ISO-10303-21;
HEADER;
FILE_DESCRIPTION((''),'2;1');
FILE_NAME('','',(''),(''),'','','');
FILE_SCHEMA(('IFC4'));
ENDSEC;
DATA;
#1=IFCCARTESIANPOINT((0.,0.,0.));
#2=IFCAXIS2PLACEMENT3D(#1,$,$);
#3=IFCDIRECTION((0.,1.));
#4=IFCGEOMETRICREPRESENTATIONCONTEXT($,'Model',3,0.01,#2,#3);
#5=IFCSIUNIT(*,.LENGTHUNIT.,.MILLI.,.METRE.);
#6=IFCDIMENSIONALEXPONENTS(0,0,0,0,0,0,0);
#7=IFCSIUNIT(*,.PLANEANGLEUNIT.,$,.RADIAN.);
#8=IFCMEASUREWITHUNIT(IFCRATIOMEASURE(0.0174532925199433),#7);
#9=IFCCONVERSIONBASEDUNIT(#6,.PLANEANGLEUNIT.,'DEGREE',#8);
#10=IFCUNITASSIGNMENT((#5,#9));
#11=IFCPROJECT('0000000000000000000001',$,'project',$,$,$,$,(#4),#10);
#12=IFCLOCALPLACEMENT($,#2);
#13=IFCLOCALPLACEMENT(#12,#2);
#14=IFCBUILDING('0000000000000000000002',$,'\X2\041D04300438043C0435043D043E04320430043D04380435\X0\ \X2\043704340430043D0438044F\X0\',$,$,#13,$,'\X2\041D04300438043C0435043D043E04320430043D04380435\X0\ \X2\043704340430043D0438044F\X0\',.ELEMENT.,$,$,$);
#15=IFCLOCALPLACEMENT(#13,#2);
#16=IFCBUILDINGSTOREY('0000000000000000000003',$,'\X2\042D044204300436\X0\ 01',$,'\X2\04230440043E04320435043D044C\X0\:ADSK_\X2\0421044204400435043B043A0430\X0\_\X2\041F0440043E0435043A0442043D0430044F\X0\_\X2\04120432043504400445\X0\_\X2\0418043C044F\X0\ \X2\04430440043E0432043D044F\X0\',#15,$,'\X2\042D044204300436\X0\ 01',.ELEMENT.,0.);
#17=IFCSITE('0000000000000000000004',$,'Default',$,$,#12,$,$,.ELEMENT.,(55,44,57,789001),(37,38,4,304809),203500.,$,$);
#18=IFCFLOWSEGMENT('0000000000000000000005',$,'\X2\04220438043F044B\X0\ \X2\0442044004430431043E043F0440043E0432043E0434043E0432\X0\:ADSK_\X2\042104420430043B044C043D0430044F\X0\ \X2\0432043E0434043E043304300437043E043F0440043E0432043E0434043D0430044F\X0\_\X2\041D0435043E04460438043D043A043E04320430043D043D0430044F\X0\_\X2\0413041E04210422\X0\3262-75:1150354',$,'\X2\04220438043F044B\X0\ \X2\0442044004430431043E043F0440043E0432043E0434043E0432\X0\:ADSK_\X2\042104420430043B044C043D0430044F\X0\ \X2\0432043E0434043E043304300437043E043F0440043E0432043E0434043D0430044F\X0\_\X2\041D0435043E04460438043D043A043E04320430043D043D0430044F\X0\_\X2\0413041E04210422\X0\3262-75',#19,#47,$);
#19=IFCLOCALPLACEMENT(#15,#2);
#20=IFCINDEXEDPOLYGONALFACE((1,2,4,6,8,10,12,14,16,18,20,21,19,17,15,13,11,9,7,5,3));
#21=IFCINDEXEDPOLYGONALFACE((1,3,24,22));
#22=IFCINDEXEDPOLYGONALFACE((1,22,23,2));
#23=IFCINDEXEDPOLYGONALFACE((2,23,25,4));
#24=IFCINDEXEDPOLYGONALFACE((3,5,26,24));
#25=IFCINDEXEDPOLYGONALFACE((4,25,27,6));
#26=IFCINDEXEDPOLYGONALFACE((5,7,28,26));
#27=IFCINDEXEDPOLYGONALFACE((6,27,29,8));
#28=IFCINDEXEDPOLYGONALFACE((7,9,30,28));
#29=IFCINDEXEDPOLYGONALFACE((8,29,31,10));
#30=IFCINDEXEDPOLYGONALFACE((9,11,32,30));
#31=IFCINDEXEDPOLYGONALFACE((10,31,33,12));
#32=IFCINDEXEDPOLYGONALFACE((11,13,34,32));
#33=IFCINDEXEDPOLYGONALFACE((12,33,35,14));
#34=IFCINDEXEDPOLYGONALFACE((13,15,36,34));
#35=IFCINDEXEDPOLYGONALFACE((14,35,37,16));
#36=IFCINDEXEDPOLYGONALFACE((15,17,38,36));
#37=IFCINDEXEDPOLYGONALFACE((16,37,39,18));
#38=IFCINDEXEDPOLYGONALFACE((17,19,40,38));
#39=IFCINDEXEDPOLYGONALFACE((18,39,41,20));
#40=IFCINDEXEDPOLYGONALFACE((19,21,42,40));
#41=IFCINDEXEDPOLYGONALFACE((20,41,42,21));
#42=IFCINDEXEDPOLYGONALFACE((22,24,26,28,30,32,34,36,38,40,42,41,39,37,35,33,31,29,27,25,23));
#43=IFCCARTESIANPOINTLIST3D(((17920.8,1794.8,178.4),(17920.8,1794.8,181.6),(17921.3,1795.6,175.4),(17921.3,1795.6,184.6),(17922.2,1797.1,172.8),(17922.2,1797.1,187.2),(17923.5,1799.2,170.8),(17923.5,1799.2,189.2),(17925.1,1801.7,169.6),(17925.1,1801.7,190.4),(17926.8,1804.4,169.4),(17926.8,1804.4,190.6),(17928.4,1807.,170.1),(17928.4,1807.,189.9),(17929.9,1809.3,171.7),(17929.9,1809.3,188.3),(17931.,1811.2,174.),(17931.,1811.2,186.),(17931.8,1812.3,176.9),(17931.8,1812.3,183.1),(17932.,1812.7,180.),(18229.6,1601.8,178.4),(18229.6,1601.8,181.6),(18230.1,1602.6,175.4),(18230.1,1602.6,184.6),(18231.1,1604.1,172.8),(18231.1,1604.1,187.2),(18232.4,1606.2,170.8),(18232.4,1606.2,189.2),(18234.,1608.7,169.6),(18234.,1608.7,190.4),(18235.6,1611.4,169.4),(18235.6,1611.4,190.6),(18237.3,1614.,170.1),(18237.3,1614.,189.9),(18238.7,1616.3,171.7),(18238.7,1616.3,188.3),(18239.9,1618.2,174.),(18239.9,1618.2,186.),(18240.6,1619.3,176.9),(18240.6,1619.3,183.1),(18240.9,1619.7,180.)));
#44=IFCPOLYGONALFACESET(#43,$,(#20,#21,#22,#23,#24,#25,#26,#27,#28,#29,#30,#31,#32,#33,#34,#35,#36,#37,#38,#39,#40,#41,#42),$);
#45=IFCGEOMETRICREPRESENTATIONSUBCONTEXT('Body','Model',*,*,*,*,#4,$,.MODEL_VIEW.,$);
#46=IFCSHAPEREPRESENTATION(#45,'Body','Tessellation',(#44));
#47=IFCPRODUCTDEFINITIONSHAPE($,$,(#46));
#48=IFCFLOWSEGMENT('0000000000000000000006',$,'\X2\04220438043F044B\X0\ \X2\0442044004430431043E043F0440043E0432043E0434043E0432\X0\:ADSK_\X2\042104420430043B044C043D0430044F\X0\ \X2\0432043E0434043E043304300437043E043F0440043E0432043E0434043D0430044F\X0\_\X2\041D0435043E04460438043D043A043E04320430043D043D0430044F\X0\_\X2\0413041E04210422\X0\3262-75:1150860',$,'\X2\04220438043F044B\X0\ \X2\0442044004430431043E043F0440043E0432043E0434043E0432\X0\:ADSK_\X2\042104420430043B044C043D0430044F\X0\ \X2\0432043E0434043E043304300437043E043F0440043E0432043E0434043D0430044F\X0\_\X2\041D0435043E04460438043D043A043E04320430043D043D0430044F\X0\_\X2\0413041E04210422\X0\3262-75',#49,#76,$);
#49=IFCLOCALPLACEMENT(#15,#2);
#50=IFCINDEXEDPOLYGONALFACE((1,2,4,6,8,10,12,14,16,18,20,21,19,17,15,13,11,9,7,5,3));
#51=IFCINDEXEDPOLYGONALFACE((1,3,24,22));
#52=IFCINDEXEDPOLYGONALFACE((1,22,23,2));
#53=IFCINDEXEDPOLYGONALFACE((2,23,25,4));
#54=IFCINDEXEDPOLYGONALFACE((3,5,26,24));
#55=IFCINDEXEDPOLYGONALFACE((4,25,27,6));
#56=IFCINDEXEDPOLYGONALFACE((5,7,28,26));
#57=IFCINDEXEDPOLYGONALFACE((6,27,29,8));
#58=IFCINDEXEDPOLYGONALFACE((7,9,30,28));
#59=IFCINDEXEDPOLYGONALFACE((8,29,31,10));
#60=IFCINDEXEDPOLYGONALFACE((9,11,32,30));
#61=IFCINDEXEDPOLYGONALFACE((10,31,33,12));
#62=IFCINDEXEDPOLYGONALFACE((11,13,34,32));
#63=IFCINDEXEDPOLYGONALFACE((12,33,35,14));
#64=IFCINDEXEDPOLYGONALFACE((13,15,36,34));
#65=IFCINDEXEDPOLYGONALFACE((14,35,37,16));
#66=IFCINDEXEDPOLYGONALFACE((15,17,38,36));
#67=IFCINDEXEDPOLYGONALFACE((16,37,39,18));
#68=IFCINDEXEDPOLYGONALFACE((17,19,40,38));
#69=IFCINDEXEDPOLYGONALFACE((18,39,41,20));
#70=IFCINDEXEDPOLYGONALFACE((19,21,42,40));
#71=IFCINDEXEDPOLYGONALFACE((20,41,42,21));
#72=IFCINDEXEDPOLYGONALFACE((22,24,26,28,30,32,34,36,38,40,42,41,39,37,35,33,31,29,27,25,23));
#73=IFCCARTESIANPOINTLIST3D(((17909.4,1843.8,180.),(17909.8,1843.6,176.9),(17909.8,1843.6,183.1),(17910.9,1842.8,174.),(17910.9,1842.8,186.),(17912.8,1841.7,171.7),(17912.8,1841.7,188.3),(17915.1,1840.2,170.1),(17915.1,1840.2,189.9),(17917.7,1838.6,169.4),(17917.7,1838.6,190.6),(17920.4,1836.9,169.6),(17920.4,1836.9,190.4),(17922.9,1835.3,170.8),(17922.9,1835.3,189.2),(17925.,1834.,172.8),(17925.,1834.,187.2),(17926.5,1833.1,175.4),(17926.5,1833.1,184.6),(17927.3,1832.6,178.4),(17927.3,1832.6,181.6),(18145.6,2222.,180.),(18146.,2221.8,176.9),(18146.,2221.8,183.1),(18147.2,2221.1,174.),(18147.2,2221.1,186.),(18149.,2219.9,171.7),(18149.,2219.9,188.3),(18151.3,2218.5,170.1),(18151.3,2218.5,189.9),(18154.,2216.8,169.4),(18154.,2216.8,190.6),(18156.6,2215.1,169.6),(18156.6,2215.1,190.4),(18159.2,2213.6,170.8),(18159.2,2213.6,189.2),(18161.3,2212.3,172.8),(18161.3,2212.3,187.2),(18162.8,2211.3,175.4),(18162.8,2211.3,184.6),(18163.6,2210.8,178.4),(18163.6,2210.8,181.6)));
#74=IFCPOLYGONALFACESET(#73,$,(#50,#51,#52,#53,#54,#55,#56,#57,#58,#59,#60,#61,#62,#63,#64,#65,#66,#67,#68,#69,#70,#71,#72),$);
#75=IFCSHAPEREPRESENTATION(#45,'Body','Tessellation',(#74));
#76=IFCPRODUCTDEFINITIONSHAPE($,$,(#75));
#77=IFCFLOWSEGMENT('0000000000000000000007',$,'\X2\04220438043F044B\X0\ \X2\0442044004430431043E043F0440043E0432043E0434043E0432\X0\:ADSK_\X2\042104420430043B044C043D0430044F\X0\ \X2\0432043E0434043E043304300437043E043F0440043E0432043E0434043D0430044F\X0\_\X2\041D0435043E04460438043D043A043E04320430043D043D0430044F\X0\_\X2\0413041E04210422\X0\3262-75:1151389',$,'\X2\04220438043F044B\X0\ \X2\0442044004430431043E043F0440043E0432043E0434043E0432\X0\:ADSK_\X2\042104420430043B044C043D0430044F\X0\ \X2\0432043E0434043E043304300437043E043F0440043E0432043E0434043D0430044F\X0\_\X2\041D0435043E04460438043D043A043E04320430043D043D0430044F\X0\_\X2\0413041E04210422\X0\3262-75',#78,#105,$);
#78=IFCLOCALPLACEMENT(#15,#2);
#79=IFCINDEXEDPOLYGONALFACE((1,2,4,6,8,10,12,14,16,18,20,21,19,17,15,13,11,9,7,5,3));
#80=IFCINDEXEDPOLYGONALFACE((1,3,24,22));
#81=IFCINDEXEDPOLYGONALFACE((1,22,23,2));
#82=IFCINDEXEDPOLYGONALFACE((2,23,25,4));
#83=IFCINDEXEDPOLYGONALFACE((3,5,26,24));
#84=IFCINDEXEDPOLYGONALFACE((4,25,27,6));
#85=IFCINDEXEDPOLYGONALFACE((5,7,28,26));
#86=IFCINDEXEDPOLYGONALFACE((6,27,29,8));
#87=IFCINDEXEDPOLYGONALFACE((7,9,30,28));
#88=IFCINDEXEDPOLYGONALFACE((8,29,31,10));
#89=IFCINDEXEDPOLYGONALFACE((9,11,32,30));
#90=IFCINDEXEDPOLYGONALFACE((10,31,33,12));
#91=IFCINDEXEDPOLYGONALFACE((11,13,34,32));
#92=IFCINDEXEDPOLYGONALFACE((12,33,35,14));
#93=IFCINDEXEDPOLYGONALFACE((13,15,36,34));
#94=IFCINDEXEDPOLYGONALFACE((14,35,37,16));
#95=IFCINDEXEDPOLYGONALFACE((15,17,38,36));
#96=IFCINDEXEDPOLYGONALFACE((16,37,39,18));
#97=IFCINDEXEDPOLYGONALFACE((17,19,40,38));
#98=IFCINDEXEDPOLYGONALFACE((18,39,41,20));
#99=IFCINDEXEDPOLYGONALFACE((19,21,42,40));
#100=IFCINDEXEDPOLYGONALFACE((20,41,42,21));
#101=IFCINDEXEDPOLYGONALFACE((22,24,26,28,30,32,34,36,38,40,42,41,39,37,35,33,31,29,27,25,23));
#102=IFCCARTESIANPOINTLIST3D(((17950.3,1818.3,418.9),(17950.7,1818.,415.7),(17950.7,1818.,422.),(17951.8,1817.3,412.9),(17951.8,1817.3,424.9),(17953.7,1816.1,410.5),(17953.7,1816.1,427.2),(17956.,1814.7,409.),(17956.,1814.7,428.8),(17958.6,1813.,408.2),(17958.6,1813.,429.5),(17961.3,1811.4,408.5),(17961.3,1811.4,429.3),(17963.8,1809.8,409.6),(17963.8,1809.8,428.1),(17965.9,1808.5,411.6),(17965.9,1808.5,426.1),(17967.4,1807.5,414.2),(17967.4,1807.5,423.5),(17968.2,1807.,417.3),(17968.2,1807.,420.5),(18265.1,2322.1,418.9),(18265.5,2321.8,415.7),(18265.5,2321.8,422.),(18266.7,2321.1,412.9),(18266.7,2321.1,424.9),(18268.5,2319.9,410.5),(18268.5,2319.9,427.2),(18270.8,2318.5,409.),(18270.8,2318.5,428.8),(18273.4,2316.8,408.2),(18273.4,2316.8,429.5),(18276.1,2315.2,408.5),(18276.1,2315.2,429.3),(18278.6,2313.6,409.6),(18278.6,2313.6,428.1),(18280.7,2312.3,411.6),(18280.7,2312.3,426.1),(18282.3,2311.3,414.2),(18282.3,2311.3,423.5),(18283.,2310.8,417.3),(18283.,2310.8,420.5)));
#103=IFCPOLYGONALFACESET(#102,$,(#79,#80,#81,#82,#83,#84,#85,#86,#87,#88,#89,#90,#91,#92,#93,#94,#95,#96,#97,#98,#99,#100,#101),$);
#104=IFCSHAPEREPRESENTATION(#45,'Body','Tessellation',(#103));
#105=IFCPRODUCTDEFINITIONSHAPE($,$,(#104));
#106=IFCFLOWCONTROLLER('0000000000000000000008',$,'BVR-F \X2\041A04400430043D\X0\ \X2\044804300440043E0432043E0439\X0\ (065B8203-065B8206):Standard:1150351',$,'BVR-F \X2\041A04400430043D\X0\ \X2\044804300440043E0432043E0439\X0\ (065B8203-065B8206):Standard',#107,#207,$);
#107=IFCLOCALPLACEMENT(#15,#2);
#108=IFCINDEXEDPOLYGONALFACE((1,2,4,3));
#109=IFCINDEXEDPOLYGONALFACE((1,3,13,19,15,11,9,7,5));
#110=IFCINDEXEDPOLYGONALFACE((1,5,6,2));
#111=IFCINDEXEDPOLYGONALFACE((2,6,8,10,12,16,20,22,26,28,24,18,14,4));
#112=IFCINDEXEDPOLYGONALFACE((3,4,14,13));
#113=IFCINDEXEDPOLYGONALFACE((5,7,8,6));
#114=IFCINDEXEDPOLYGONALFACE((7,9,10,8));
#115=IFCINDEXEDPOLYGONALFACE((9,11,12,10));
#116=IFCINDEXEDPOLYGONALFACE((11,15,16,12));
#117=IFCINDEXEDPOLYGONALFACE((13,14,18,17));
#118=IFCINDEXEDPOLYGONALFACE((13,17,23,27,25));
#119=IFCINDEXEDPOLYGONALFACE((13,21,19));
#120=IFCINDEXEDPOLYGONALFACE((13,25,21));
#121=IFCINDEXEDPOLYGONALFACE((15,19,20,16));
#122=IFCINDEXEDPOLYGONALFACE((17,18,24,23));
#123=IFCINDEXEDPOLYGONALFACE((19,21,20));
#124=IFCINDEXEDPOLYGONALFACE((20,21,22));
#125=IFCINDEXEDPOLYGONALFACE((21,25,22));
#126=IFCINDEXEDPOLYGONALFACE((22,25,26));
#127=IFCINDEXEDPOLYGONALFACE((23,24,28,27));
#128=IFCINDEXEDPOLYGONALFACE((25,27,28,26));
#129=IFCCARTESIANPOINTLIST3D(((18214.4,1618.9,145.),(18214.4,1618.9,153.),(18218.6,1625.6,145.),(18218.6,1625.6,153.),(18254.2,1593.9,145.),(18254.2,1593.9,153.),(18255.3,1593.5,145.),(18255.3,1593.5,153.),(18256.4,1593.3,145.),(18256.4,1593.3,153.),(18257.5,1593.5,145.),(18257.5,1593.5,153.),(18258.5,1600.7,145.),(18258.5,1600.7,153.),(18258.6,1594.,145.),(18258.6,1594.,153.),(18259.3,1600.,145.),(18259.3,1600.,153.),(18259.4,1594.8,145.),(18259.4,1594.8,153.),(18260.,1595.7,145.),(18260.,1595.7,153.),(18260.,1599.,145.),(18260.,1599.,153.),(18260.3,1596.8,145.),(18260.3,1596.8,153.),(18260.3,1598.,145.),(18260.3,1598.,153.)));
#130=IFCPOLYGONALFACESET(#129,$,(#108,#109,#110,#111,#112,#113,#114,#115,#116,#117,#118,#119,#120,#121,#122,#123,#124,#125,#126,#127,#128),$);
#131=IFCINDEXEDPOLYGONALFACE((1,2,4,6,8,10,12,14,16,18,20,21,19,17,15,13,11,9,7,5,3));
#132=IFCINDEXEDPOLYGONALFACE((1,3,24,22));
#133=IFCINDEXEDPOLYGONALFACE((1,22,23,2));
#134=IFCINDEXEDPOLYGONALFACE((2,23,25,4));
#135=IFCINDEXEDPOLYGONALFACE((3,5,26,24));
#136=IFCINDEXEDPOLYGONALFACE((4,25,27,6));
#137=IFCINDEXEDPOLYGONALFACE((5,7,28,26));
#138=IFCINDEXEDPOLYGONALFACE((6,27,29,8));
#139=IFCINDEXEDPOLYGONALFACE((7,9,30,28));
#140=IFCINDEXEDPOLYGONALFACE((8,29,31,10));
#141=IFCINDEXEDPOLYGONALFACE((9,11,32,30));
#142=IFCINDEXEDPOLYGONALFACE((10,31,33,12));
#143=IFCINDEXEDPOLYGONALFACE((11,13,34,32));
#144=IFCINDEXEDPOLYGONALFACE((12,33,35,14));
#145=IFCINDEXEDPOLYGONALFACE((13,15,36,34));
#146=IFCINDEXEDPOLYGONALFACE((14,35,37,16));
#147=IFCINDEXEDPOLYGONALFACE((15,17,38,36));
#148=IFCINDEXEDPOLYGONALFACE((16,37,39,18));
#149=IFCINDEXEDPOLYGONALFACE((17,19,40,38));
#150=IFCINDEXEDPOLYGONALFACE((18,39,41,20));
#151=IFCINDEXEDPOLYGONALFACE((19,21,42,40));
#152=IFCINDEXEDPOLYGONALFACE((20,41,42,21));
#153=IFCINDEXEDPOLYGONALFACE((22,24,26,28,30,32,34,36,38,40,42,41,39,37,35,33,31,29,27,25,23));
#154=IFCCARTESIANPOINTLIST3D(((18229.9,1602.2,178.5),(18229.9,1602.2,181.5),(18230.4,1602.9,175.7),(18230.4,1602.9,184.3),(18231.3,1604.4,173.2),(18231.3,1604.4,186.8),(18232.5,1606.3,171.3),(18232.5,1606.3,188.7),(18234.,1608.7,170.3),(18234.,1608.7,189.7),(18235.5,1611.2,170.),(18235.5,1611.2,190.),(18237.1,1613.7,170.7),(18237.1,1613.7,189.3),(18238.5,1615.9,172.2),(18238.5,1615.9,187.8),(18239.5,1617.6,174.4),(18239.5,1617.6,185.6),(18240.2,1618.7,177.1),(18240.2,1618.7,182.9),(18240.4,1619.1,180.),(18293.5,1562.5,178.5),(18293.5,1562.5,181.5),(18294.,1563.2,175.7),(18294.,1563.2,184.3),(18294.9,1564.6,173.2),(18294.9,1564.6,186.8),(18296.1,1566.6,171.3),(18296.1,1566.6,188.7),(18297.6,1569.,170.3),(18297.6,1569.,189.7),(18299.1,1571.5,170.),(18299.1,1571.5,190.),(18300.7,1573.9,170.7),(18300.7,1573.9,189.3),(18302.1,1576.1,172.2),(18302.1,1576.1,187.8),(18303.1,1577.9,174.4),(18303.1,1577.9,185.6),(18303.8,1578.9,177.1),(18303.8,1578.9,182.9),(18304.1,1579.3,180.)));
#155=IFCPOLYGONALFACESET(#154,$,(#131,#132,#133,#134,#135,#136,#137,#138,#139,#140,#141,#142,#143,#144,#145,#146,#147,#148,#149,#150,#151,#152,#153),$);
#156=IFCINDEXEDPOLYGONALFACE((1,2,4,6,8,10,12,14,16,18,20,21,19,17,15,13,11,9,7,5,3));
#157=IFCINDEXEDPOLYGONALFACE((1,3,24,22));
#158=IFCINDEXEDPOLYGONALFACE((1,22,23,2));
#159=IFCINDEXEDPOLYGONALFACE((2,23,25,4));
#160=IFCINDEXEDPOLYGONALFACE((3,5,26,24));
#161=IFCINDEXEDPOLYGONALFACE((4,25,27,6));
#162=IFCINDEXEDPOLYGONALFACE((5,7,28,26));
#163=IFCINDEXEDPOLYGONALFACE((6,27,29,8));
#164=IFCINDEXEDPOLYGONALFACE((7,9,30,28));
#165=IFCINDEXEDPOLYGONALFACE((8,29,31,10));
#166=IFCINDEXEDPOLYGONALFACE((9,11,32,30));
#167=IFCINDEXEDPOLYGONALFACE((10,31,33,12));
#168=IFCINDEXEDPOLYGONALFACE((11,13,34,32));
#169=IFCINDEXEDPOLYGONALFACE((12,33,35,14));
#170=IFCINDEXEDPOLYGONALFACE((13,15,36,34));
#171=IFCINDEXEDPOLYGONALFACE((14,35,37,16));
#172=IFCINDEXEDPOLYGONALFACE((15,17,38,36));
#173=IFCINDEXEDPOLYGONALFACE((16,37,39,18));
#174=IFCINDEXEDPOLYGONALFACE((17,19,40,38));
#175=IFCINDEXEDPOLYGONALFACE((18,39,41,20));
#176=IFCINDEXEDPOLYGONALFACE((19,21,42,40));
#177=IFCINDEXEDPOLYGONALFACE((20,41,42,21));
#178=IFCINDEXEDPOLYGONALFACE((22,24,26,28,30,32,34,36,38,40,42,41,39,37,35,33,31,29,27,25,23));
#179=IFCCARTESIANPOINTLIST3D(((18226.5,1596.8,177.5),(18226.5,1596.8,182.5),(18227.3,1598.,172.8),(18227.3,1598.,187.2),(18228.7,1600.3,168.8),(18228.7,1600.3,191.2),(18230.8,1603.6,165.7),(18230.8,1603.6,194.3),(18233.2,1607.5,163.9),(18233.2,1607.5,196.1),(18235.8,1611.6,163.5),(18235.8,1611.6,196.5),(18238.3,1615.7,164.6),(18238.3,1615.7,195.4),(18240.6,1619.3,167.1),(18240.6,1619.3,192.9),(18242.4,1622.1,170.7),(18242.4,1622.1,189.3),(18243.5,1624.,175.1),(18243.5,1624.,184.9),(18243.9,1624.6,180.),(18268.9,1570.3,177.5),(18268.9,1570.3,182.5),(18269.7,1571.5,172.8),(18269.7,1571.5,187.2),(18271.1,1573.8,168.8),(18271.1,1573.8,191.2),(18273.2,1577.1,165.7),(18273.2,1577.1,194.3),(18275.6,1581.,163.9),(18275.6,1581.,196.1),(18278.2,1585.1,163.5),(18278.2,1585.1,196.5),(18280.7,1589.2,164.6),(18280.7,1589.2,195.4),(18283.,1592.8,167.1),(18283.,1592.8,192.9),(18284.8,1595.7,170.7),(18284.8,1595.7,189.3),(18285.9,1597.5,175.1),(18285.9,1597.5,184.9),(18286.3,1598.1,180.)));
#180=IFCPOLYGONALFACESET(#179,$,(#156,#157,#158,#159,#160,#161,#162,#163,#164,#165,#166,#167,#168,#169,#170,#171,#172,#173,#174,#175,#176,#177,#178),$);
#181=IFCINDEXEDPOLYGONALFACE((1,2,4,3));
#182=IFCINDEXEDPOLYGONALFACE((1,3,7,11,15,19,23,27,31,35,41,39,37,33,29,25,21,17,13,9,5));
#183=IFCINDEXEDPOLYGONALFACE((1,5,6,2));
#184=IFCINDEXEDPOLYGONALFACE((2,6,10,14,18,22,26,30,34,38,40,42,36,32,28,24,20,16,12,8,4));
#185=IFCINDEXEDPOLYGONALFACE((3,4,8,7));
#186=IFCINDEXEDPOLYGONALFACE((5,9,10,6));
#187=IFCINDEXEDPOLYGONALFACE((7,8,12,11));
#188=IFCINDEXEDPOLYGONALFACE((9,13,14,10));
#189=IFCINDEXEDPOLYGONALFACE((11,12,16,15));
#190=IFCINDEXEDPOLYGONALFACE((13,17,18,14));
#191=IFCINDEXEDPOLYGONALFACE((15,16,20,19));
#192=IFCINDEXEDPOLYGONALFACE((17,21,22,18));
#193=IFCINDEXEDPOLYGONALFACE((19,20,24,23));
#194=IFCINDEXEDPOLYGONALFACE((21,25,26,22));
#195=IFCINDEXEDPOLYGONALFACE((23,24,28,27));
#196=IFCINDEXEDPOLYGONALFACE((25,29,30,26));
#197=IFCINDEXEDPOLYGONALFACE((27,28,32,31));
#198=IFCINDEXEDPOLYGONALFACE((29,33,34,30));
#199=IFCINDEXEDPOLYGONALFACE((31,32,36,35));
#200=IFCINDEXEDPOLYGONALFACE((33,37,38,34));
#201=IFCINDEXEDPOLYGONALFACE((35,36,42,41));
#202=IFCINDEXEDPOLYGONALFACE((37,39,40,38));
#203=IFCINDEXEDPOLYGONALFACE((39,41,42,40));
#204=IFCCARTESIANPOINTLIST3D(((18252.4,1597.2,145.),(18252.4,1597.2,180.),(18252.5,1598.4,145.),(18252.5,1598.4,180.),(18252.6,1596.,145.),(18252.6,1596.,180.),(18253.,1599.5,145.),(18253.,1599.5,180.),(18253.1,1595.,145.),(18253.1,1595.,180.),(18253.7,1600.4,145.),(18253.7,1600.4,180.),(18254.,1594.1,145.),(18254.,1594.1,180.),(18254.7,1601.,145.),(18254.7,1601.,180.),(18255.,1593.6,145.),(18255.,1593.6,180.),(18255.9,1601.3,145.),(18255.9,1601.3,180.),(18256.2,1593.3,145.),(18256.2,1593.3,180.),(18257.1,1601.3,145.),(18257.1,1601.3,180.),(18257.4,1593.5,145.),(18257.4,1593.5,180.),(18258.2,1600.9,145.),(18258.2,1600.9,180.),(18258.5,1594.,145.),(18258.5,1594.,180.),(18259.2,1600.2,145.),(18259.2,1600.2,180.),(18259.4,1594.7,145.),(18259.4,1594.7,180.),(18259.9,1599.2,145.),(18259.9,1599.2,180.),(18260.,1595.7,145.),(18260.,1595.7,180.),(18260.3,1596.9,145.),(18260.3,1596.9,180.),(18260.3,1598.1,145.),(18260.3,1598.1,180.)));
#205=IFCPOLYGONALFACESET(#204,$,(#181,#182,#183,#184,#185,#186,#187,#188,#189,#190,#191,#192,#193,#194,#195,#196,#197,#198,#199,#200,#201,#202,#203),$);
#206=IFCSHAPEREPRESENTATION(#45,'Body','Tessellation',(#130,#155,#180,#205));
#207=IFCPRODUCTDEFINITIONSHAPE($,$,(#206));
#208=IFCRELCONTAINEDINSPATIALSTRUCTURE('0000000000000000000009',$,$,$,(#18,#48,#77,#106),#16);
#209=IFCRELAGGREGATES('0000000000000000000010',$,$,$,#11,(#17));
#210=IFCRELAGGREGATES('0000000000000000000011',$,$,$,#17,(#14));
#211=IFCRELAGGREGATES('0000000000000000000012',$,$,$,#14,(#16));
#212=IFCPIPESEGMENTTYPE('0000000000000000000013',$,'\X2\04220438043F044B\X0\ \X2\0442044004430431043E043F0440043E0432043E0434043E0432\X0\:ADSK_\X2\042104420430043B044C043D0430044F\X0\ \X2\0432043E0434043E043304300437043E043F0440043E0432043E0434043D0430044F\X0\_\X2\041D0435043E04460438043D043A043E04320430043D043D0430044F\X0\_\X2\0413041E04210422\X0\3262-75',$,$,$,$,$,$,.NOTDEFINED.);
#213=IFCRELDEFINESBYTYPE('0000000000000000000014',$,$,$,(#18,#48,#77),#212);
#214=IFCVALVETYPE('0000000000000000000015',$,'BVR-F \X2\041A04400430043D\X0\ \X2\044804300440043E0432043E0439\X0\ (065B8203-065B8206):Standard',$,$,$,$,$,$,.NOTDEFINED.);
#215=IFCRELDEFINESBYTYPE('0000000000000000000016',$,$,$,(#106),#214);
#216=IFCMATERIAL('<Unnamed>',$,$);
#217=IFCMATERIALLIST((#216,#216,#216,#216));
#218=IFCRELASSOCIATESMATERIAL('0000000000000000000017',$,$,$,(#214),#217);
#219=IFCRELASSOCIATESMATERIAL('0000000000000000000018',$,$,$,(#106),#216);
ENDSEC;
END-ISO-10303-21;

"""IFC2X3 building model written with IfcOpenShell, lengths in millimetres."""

from ifc_helpers import new_model, entity, si_unit, converted_unit, direction, frame, frame_2d, origin, origin_2d_with_axis, place, context, subcontext, project, spatial, polyline, circle_curve, parameter, trimmed, segment, composite_curve, circle, outline, extrude, source, transform, mapped, material, material_list, type_object, type_shapes, element, save


model = new_model("IFC2X3")

# Units and contexts
model_context = context("Model", 3, precision=0.01, world=origin(), true_north=direction((0.0, 1.0)))
body_context = subcontext(model_context, "Body", "Model", "MODEL_VIEW")
ifc_project = project(units=[si_unit("LENGTHUNIT", "METRE", prefix="MILLI"), converted_unit("PLANEANGLEUNIT", "DEGREE", entity("IfcRatioMeasure", 0.0174532925199433), si_unit("PLANEANGLEUNIT", "RADIAN"), dimensions=[0, 0, 0, 0, 0, 0, 0])], contexts=[model_context])

# Site, building, storey
site_placement = place(None, origin())
site = spatial("IfcSite", under=ifc_project, at=site_placement, Name="Default", CompositionType="ELEMENT", RefLatitude=(55, 44, 57, 789001), RefLongitude=(37, 38, 4, 304809), RefElevation=203500.0)
building_placement = place(site_placement, origin())
building = spatial("IfcBuilding", under=site, at=building_placement, Name="Наименование здания", LongName="Наименование здания", CompositionType="ELEMENT")
storey_placement = place(building_placement, origin())
storey = spatial("IfcBuildingStorey", under=building, at=storey_placement, Name="Этаж 01", ObjectType="Уровень:ADSK_Стрелка_Проектная_Вверх_Имя уровня", LongName="Этаж 01", CompositionType="ELEMENT", Elevation=0.0)

# Flow segments
pipe_segment_type = type_object("IfcPipeSegmentType", Name="Типы трубопроводов:ADSK_Стальная водогазопроводная_Неоцинкованная_ГОСТ3262-75", PredefinedType="NOTDEFINED")
flow_segment_1_placement = place(storey_placement, frame((17919.1, 1600.1, 167.8)))
element("IfcFlowSegment", 1, at=flow_segment_1_placement, inside=storey, type_object=pipe_segment_type, Name="Типы трубопроводов:ADSK_Стальная водогазопроводная_Неоцинкованная_ГОСТ3262-75:1150354", ObjectType="Типы трубопроводов:ADSK_Стальная водогазопроводная_Неоцинкованная_ГОСТ3262-75", context=body_context, shape_type="SweptSolid", body=[
    extrude(circle(Radius=10.7, at=origin_2d_with_axis()), frame((7.2, 203.6, 12.2), z_axis=(0.848046, -0.529923, 0.0), x_axis=(0.529923, 0.848046, 0.0)), (0.0, 0.0, 1.0), 364.2),
])
flow_segment_2_placement = place(storey_placement, frame((17907.8, 1830.9, 167.8)))
element("IfcFlowSegment", 2, at=flow_segment_2_placement, inside=storey, type_object=pipe_segment_type, Name="Типы трубопроводов:ADSK_Стальная водогазопроводная_Неоцинкованная_ГОСТ3262-75:1150860", ObjectType="Типы трубопроводов:ADSK_Стальная водогазопроводная_Неоцинкованная_ГОСТ3262-75", context=body_context, shape_type="SweptSolid", body=[
    extrude(circle(Radius=10.7, at=origin_2d_with_axis()), frame((10.6, 7.2, 12.2), z_axis=(0.529712, 0.848177, 0.0), x_axis=(-0.848177, 0.529712, 0.0)), (0.0, 0.0, 1.0), 445.9),
])
flow_segment_3_placement = place(storey_placement, frame((17948.7, 1805.4, 406.6)))
element("IfcFlowSegment", 3, at=flow_segment_3_placement, inside=storey, type_object=pipe_segment_type, Name="Типы трубопроводов:ADSK_Стальная водогазопроводная_Неоцинкованная_ГОСТ3262-75:1151389", ObjectType="Типы трубопроводов:ADSK_Стальная водогазопроводная_Неоцинкованная_ГОСТ3262-75", context=body_context, shape_type="SweptSolid", body=[
    extrude(circle(Radius=10.7, at=origin_2d_with_axis()), frame((10.6, 7.2, 12.2), z_axis=(0.529939, 0.848036, 0.0), x_axis=(-0.848036, 0.529939, 0.0)), (0.0, 0.0, 1.0), 594.1),
])

# Flow controller
ifc_material = material(Name="<Unnamed>")
ifc_material_list = material_list([ifc_material, ifc_material, ifc_material, ifc_material])
valve_type_1 = type_object("IfcValveType", Name="BVR-F Кран шаровой (065B8203-065B8206):Standard", PredefinedType="NOTDEFINED", material=ifc_material_list)
shared_shape_1 = source(origin(), body_context, "Body", "SweptSolid", [
    extrude(outline(composite_curve([segment(polyline([(-23.5, -4.0), (23.5, -4.0)]), True, "CONTINUOUS"), segment(polyline([(23.5, -4.0), (23.5, 4.0)]), True, "CONTINUOUS"), segment(polyline([(23.5, 4.0), (-23.5, 4.0)]), True, "CONTINUOUS"), segment(trimmed(circle_curve(frame_2d((-23.5, 0.0), x_axis=(1.0, 0.0)), 4.0), [parameter(90.0)], [parameter(270.0)], True, "PARAMETER"), True, "CONTINUOUS")], self_intersect=False)), frame((23.5, 0.0, 26.9)), (0.0, 0.0, 1.0), 8.0),
    extrude(circle(Radius=10.0, at=origin_2d_with_axis()), frame((-50.0, 0.0, 0.0), z_axis=(1.0, 0.0, 0.0), x_axis=(0.0, 1.0, 0.0)), (0.0, 0.0, 1.0), 75.0),
    extrude(circle(Radius=16.5, at=origin_2d_with_axis()), frame((-25.0, 0.0, 0.0), z_axis=(1.0, 0.0, 0.0), x_axis=(0.0, 1.0, 0.0)), (0.0, 0.0, 1.0), 50.0),
    extrude(circle(Radius=4.0, at=origin_2d_with_axis()), origin(), (0.0, 0.0, 1.0), 35.0),
])
type_shapes(valve_type_1, [shared_shape_1])
flow_controller_1_placement = place(storey_placement, frame((18256.3, 1597.3, 180.0), z_axis=(0.0, 0.0, -1.0), x_axis=(-0.848046, 0.529923, 0.0)))
element("IfcFlowController", 4, at=flow_controller_1_placement, inside=storey, type_object=valve_type_1, material=ifc_material, Name="BVR-F Кран шаровой (065B8203-065B8206):Standard:1150351", ObjectType="BVR-F Кран шаровой (065B8203-065B8206):Standard", context=body_context, shape_type="MappedRepresentation", body=[
    mapped(shared_shape_1, transform((0.0, 0.0, 0.0), scale=1.0)),
])

save(model, "model.ifc")
